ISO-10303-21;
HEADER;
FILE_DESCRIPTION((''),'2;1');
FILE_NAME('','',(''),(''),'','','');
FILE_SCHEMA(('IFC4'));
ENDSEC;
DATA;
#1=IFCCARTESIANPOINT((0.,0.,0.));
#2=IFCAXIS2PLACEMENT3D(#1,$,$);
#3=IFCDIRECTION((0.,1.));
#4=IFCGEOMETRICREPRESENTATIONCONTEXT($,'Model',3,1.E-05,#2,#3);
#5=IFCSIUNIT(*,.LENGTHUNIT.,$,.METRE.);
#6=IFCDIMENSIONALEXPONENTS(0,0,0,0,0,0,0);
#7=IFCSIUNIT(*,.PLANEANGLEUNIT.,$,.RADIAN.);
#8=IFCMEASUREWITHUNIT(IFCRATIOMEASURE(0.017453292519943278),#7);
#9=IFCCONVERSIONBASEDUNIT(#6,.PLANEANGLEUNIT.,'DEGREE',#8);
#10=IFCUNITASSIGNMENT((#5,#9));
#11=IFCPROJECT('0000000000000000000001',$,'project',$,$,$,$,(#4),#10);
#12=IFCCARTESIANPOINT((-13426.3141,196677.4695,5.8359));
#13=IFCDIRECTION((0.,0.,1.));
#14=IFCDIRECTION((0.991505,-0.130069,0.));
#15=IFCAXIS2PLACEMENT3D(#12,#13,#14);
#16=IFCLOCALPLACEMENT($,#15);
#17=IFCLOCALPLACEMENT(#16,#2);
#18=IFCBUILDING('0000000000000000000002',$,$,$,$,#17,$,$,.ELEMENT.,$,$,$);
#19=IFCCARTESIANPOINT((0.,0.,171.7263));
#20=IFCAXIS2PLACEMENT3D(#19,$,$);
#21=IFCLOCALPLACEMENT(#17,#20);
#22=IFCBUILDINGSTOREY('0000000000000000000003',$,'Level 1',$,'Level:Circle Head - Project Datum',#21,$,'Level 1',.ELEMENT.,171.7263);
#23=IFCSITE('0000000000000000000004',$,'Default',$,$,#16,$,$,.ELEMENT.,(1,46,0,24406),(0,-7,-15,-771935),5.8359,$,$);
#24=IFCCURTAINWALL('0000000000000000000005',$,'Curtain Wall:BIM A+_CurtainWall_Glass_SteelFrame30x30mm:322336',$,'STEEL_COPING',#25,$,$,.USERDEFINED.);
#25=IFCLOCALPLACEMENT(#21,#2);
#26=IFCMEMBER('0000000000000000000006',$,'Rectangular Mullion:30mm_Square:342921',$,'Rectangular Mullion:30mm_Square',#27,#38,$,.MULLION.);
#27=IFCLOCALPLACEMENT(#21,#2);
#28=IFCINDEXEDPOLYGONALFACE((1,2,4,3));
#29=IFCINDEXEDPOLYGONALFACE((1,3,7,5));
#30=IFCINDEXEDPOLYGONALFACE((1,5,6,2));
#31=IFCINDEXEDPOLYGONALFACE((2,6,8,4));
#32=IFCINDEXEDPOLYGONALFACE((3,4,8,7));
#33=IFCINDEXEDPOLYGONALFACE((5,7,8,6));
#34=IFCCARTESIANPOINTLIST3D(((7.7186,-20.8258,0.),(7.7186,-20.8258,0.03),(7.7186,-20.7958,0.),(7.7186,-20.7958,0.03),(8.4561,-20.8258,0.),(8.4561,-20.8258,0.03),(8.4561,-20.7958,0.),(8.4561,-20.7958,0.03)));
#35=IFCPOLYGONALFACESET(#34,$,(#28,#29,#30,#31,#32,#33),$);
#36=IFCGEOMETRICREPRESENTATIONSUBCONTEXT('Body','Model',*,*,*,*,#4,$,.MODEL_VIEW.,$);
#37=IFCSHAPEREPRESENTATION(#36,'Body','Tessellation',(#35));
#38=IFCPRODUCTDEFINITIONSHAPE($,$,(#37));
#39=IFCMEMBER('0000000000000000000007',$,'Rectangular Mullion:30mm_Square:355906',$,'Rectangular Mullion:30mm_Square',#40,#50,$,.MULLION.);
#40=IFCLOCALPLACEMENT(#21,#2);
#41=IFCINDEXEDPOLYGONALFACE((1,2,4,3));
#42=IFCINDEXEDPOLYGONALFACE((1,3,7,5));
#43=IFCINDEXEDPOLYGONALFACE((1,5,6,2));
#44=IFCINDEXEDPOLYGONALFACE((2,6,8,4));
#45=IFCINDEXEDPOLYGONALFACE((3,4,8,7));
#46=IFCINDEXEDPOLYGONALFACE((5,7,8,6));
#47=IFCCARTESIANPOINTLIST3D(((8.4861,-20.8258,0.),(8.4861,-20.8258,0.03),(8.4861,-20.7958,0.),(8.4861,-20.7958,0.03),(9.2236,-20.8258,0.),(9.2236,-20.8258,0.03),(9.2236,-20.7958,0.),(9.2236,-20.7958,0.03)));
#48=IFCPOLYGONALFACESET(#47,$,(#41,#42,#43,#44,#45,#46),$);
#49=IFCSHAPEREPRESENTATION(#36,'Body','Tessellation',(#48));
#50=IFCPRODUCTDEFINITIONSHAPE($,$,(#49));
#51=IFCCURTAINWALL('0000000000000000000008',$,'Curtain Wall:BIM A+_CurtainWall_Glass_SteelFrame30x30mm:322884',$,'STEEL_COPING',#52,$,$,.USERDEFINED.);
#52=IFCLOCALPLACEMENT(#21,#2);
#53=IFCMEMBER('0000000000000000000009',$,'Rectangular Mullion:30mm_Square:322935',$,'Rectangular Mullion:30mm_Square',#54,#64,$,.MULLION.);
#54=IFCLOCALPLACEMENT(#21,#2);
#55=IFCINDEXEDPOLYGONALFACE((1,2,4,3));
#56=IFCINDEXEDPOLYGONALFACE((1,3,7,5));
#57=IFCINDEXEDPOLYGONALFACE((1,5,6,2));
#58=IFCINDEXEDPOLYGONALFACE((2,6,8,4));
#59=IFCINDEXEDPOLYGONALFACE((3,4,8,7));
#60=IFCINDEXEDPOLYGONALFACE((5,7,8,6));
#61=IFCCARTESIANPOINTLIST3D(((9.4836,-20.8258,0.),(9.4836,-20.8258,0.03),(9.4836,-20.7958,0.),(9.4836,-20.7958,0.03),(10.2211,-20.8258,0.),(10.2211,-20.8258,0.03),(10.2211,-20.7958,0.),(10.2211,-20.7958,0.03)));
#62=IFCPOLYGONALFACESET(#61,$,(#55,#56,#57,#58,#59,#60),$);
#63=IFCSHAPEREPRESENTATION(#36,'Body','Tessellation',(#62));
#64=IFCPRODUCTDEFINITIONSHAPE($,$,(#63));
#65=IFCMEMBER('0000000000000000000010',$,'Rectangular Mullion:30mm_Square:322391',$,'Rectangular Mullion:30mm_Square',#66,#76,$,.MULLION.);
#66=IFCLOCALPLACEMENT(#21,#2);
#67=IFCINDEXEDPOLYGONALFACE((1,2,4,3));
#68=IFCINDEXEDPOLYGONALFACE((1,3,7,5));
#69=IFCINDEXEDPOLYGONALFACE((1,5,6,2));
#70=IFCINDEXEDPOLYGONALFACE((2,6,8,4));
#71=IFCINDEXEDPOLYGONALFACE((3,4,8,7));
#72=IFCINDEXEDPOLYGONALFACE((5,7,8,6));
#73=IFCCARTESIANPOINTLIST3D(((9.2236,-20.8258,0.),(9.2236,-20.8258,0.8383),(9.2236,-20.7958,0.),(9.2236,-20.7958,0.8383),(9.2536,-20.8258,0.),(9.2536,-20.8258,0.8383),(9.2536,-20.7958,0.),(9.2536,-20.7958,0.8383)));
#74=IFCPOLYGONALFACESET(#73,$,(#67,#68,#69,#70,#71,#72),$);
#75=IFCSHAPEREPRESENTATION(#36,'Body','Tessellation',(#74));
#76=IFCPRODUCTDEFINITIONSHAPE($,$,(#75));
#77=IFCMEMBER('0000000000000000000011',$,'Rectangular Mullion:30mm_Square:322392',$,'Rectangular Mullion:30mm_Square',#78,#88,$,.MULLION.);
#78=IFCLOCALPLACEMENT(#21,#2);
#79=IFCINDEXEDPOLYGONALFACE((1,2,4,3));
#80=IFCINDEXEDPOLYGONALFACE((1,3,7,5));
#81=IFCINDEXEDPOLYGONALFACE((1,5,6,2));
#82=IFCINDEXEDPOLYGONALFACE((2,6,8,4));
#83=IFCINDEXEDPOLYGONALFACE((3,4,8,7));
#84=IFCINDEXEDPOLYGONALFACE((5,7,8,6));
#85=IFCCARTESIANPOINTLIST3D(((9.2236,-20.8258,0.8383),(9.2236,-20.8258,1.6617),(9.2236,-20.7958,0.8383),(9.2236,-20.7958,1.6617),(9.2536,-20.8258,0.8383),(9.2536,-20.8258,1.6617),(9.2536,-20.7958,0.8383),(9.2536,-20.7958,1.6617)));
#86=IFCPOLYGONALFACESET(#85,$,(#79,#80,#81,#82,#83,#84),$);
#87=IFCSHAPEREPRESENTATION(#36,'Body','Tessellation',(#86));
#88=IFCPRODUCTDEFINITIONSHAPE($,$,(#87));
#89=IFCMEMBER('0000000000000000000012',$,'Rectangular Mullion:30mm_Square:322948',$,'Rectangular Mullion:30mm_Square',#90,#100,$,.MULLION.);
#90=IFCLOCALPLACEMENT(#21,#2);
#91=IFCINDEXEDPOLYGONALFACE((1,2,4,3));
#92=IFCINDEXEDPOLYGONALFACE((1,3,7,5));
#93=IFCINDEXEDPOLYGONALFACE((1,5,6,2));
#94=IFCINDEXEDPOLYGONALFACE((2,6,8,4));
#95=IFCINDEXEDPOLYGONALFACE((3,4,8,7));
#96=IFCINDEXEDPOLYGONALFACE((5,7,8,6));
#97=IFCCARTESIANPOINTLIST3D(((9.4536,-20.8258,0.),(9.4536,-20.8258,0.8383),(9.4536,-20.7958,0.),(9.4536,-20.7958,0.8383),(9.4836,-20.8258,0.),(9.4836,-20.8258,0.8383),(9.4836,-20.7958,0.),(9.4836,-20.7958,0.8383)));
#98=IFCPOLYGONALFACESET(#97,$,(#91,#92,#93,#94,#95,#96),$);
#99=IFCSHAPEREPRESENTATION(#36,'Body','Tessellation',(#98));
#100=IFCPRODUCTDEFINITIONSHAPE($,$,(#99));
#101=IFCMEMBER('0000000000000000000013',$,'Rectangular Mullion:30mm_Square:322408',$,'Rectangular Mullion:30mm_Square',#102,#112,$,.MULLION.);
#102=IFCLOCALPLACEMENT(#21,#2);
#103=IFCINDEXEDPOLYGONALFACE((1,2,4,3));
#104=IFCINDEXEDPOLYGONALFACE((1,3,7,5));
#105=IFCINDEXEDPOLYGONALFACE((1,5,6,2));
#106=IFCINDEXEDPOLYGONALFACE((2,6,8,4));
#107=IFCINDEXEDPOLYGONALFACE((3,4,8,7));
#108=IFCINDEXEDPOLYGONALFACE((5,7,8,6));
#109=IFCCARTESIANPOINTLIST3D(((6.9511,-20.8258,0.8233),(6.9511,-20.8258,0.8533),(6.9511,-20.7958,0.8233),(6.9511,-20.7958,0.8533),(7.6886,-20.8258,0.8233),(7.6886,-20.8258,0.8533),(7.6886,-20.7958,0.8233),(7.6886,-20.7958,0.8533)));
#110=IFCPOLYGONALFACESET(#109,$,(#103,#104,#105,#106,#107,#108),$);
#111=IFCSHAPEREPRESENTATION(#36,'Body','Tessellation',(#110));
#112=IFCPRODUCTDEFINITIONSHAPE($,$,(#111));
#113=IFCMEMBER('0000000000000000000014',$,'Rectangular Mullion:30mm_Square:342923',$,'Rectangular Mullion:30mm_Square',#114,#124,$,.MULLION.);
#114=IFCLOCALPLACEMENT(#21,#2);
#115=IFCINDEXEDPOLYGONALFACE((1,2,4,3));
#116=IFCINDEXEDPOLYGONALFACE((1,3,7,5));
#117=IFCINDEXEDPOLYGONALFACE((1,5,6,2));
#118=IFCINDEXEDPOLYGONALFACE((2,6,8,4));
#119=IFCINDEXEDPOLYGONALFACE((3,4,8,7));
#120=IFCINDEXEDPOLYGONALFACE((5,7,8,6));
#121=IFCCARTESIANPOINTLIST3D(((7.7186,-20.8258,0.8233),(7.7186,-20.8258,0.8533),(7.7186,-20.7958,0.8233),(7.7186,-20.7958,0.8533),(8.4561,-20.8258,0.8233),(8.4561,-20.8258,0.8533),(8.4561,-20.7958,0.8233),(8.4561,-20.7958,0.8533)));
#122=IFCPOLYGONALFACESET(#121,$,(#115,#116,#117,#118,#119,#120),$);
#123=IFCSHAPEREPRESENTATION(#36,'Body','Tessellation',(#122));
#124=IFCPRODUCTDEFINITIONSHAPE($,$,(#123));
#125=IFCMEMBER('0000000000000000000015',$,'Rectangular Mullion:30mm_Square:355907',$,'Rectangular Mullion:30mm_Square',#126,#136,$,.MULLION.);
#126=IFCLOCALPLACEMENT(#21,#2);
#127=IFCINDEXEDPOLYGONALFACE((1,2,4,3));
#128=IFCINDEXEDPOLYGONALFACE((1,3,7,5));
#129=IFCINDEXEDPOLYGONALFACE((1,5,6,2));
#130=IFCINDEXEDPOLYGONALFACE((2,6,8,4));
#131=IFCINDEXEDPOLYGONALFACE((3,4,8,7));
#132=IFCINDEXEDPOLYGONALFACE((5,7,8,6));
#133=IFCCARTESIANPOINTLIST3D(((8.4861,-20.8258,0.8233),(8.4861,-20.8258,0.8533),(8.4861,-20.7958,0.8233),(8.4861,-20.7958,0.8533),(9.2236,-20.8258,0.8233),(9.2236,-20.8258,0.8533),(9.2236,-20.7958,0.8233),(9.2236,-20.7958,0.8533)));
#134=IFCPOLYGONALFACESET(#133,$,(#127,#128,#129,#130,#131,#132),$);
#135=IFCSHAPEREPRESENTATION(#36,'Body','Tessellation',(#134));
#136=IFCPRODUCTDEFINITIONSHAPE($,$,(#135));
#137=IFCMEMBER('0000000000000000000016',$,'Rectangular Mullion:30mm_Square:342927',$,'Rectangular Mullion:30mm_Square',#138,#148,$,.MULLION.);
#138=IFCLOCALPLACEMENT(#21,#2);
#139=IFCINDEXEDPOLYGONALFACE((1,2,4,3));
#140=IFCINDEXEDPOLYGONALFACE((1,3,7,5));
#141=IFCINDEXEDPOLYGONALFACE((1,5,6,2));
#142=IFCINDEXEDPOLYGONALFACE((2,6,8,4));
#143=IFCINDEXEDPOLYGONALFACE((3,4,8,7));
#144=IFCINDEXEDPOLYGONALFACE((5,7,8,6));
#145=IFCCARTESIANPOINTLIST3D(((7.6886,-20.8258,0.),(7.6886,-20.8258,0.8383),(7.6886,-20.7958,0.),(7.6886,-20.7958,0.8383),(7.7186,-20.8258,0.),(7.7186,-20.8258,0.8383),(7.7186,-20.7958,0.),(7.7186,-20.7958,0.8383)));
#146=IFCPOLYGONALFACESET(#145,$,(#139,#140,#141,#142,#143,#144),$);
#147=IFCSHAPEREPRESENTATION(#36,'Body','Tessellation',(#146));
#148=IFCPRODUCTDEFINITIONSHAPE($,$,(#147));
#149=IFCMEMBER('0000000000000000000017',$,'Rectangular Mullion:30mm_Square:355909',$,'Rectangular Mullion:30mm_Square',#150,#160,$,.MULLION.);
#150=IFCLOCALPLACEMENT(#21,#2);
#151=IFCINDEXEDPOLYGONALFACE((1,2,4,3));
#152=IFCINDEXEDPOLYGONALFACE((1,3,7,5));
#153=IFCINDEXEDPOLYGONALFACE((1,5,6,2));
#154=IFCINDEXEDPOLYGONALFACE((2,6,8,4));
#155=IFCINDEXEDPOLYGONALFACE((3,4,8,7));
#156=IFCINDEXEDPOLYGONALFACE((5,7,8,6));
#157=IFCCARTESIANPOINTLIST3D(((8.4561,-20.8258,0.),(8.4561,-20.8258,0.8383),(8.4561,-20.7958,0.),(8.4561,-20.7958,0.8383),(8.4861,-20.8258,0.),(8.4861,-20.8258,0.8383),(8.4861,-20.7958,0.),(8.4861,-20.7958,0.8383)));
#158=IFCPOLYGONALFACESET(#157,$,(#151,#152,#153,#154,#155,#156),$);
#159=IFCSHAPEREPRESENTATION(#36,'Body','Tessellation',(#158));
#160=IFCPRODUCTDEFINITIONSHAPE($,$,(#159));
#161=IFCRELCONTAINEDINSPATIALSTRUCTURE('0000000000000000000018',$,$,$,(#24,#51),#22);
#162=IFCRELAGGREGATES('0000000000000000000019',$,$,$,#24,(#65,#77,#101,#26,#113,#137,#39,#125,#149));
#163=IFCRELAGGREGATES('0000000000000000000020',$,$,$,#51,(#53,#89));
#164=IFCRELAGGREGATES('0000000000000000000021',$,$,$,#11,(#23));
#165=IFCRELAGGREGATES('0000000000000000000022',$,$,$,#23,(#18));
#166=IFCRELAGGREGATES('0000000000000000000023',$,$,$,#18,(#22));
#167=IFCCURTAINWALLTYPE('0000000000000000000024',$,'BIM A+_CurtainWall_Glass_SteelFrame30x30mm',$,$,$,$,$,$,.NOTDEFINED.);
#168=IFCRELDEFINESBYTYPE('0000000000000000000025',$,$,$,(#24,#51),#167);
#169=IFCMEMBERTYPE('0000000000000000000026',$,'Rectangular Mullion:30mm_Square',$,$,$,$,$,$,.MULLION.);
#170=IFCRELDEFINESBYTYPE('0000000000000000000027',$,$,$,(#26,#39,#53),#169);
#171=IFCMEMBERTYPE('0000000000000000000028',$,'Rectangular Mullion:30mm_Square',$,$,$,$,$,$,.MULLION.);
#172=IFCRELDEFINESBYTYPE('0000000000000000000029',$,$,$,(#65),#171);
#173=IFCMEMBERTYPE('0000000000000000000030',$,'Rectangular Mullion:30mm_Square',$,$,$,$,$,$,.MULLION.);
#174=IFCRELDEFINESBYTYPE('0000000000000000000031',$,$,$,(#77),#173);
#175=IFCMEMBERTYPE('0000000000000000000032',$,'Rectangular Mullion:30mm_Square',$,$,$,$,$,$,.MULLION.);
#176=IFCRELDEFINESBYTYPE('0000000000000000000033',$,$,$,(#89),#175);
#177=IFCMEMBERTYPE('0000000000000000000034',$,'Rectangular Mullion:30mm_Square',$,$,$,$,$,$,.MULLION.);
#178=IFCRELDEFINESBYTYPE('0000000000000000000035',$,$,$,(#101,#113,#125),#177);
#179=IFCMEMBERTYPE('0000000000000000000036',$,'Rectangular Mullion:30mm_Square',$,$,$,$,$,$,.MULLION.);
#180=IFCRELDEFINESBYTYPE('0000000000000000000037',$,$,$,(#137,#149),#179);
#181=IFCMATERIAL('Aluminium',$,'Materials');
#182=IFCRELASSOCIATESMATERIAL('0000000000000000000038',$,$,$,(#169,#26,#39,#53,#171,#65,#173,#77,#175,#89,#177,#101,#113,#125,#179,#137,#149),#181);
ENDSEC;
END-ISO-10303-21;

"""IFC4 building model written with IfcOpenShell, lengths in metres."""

from ifc_helpers import new_model, entity, si_unit, converted_unit, direction, frame, origin, place, context, subcontext, project, spatial, indexed_curve, outline, extrude, source, transform, mapped, material, type_object, type_shapes, element, aggregate, save


model = new_model("IFC4")

# Units and contexts
model_context = context("Model", 3, precision=1e-05, world=origin(), true_north=direction((0.0, 1.0)))
body_context = subcontext(model_context, "Body", "Model", "MODEL_VIEW")
ifc_project = project(units=[si_unit("LENGTHUNIT", "METRE"), converted_unit("PLANEANGLEUNIT", "DEGREE", entity("IfcRatioMeasure", 0.017453292519943278), si_unit("PLANEANGLEUNIT", "RADIAN"), dimensions=[0, 0, 0, 0, 0, 0, 0])], contexts=[model_context])

# Site, building, storey
site_placement = place(None, frame((-13426.3141, 196677.4695, 5.8359), z_axis=(0.0, 0.0, 1.0), x_axis=(0.991505, -0.130069, 0.0)))
site = spatial("IfcSite", under=ifc_project, at=site_placement, Name="Default", CompositionType="ELEMENT", RefLatitude=(1, 46, 0, 24406), RefLongitude=(0, -7, -15, -771935), RefElevation=5.8359)
building_placement = place(site_placement, origin())
building = spatial("IfcBuilding", under=site, at=building_placement, CompositionType="ELEMENT")
storey_placement = place(building_placement, frame((0.0, 0.0, 171.7263)))
storey = spatial("IfcBuildingStorey", under=building, at=storey_placement, Name="Level 1", ObjectType="Level:Circle Head - Project Datum", LongName="Level 1", CompositionType="ELEMENT", Elevation=171.7263)

# Curtain wall, members
curtain_wall_type_1 = type_object("IfcCurtainWallType", Name="BIM A+_CurtainWall_Glass_SteelFrame30x30mm", PredefinedType="NOTDEFINED")
curtain_wall_1_placement = place(storey_placement, frame((0.0, 0.0, -171.7263)))
curtain_wall_1 = element("IfcCurtainWall", 1, at=curtain_wall_1_placement, inside=storey, type_object=curtain_wall_type_1, Name="Curtain Wall:BIM A+_CurtainWall_Glass_SteelFrame30x30mm:322336", ObjectType="STEEL_COPING", PredefinedType="USERDEFINED")
ifc_material_1 = material(Name="Aluminium", Category="Materials")
member_type_1 = type_object("IfcMemberType", Name="Rectangular Mullion:30mm_Square", PredefinedType="MULLION", material=ifc_material_1)
shared_shape_1 = source(origin(), body_context, "Body", "SweptSolid", [
    extrude(outline(indexed_curve([(-0.015, -0.015), (0.015, -0.015), (0.015, 0.015), (-0.015, 0.015), (-0.015, -0.015)], self_intersect=False)), frame((-0.015, 0.0, -0.7375), z_axis=(0.0, 0.0, 1.0), x_axis=(0.0, -1.0, 0.0)), (0.0, 0.0, 1.0), 0.7375),
])
type_shapes(member_type_1, [shared_shape_1])
member_1_placement = place(curtain_wall_1_placement, frame((7.7186, -20.8108, 171.7263), z_axis=(-1.0, 0.0, 0.0), x_axis=(0.0, 0.0, -1.0)))
member_1 = element("IfcMember", 2, at=member_1_placement, type_object=member_type_1, material=ifc_material_1, Name="Rectangular Mullion:30mm_Square:342921", ObjectType="Rectangular Mullion:30mm_Square", PredefinedType="MULLION", context=body_context, shape_type="MappedRepresentation", body=[
    mapped(shared_shape_1, transform((0.0, 0.0, 0.0), scale=1.0)),
])
member_2_placement = place(curtain_wall_1_placement, frame((8.4861, -20.8108, 171.7263), z_axis=(-1.0, 0.0, 0.0), x_axis=(0.0, 0.0, -1.0)))
member_2 = element("IfcMember", 3, at=member_2_placement, type_object=member_type_1, material=ifc_material_1, Name="Rectangular Mullion:30mm_Square:355906", ObjectType="Rectangular Mullion:30mm_Square", PredefinedType="MULLION", context=body_context, shape_type="MappedRepresentation", body=[
    mapped(shared_shape_1, transform((0.0, 0.0, 0.0), scale=1.0)),
])

# Curtain wall, member
curtain_wall_2_placement = place(storey_placement, frame((0.0, 0.0, -171.7263)))
curtain_wall_2 = element("IfcCurtainWall", 4, at=curtain_wall_2_placement, inside=storey, type_object=curtain_wall_type_1, Name="Curtain Wall:BIM A+_CurtainWall_Glass_SteelFrame30x30mm:322884", ObjectType="STEEL_COPING", PredefinedType="USERDEFINED")
member_3_placement = place(curtain_wall_2_placement, frame((9.4836, -20.8108, 171.7263), z_axis=(-1.0, 0.0, 0.0), x_axis=(0.0, 0.0, -1.0)))
member_3 = element("IfcMember", 5, at=member_3_placement, type_object=member_type_1, material=ifc_material_1, Name="Rectangular Mullion:30mm_Square:322935", ObjectType="Rectangular Mullion:30mm_Square", PredefinedType="MULLION", context=body_context, shape_type="MappedRepresentation", body=[
    mapped(shared_shape_1, transform((0.0, 0.0, 0.0), scale=1.0)),
])

# Members
member_type_2 = type_object("IfcMemberType", Name="Rectangular Mullion:30mm_Square", PredefinedType="MULLION", material=ifc_material_1)
shared_shape_2 = source(origin(), body_context, "Body", "SweptSolid", [
    extrude(outline(indexed_curve([(-0.015, -0.015), (0.015, -0.015), (0.015, 0.015), (-0.015, 0.015), (-0.015, -0.015)], self_intersect=False)), frame((-0.015, 0.0, -0.8383), z_axis=(0.0, 0.0, 1.0), x_axis=(0.0, -1.0, 0.0)), (0.0, 0.0, 1.0), 0.8383),
])
type_shapes(member_type_2, [shared_shape_2])
member_4_placement = place(curtain_wall_1_placement, frame((9.2536, -20.8108, 171.7263), z_axis=(0.0, 0.0, -1.0), x_axis=(1.0, 0.0, 0.0)))
member_4 = element("IfcMember", 6, at=member_4_placement, type_object=member_type_2, material=ifc_material_1, Name="Rectangular Mullion:30mm_Square:322391", ObjectType="Rectangular Mullion:30mm_Square", PredefinedType="MULLION", context=body_context, shape_type="MappedRepresentation", body=[
    mapped(shared_shape_2, transform((0.0, 0.0, 0.0), scale=1.0)),
])
member_type_3 = type_object("IfcMemberType", Name="Rectangular Mullion:30mm_Square", PredefinedType="MULLION", material=ifc_material_1)
shared_shape_3 = source(origin(), body_context, "Body", "SweptSolid", [
    extrude(outline(indexed_curve([(-0.015, -0.015), (0.015, -0.015), (0.015, 0.015), (-0.015, 0.015), (-0.015, -0.015)], self_intersect=False)), frame((-0.015, 0.0, -0.8233), z_axis=(0.0, 0.0, 1.0), x_axis=(0.0, -1.0, 0.0)), (0.0, 0.0, 1.0), 0.8233),
])
type_shapes(member_type_3, [shared_shape_3])
member_5_placement = place(curtain_wall_1_placement, frame((9.2536, -20.8108, 172.5646), z_axis=(0.0, 0.0, -1.0), x_axis=(1.0, 0.0, 0.0)))
member_5 = element("IfcMember", 7, at=member_5_placement, type_object=member_type_3, material=ifc_material_1, Name="Rectangular Mullion:30mm_Square:322392", ObjectType="Rectangular Mullion:30mm_Square", PredefinedType="MULLION", context=body_context, shape_type="MappedRepresentation", body=[
    mapped(shared_shape_3, transform((0.0, 0.0, 0.0), scale=1.0)),
])
member_type_4 = type_object("IfcMemberType", Name="Rectangular Mullion:30mm_Square", PredefinedType="MULLION", material=ifc_material_1)
shared_shape_4 = source(origin(), body_context, "Body", "SweptSolid", [
    extrude(outline(indexed_curve([(-0.015, -0.015), (0.015, -0.015), (0.015, 0.015), (-0.015, 0.015), (-0.015, -0.015)], self_intersect=False)), frame((-0.015, 0.0, -0.8383), z_axis=(0.0, 0.0, 1.0), x_axis=(0.0, -1.0, 0.0)), (0.0, 0.0, 1.0), 0.8383),
])
type_shapes(member_type_4, [shared_shape_4])
member_6_placement = place(curtain_wall_2_placement, frame((9.4536, -20.8108, 172.5646), z_axis=(0.0, 0.0, 1.0), x_axis=(-1.0, 0.0, 0.0)))
member_6 = element("IfcMember", 8, at=member_6_placement, type_object=member_type_4, material=ifc_material_1, Name="Rectangular Mullion:30mm_Square:322948", ObjectType="Rectangular Mullion:30mm_Square", PredefinedType="MULLION", context=body_context, shape_type="MappedRepresentation", body=[
    mapped(shared_shape_4, transform((0.0, 0.0, 0.0), scale=1.0)),
])
member_type_5 = type_object("IfcMemberType", Name="Rectangular Mullion:30mm_Square", PredefinedType="MULLION", material=ifc_material_1)
shared_shape_5 = source(origin(), body_context, "Body", "SweptSolid", [
    extrude(outline(indexed_curve([(-0.015, -0.015), (0.015, -0.015), (0.015, 0.015), (-0.015, 0.015), (-0.015, -0.015)], self_intersect=False)), frame((0.0, 0.0, -0.7375), z_axis=(0.0, 0.0, 1.0), x_axis=(0.0, -1.0, 0.0)), (0.0, 0.0, 1.0), 0.7375),
])
type_shapes(member_type_5, [shared_shape_5])
member_7_placement = place(curtain_wall_1_placement, frame((7.6886, -20.8108, 172.5646), z_axis=(1.0, 0.0, 0.0), x_axis=(0.0, 0.0, 1.0)))
member_7 = element("IfcMember", 9, at=member_7_placement, type_object=member_type_5, material=ifc_material_1, Name="Rectangular Mullion:30mm_Square:322408", ObjectType="Rectangular Mullion:30mm_Square", PredefinedType="MULLION", context=body_context, shape_type="MappedRepresentation", body=[
    mapped(shared_shape_5, transform((0.0, 0.0, 0.0), scale=1.0)),
])
member_8_placement = place(curtain_wall_1_placement, frame((8.4561, -20.8108, 172.5646), z_axis=(1.0, 0.0, 0.0), x_axis=(0.0, 0.0, 1.0)))
member_8 = element("IfcMember", 10, at=member_8_placement, type_object=member_type_5, material=ifc_material_1, Name="Rectangular Mullion:30mm_Square:342923", ObjectType="Rectangular Mullion:30mm_Square", PredefinedType="MULLION", context=body_context, shape_type="MappedRepresentation", body=[
    mapped(shared_shape_5, transform((0.0, 0.0, 0.0), scale=1.0)),
])
member_9_placement = place(curtain_wall_1_placement, frame((9.2236, -20.8108, 172.5646), z_axis=(1.0, 0.0, 0.0), x_axis=(0.0, 0.0, 1.0)))
member_9 = element("IfcMember", 11, at=member_9_placement, type_object=member_type_5, material=ifc_material_1, Name="Rectangular Mullion:30mm_Square:355907", ObjectType="Rectangular Mullion:30mm_Square", PredefinedType="MULLION", context=body_context, shape_type="MappedRepresentation", body=[
    mapped(shared_shape_5, transform((0.0, 0.0, 0.0), scale=1.0)),
])
member_type_6 = type_object("IfcMemberType", Name="Rectangular Mullion:30mm_Square", PredefinedType="MULLION", material=ifc_material_1)
shared_shape_6 = source(origin(), body_context, "Body", "SweptSolid", [
    extrude(outline(indexed_curve([(-0.015, -0.015), (0.015, -0.015), (0.015, 0.015), (-0.015, 0.015), (-0.015, -0.015)], self_intersect=False)), frame((0.0, 0.0, -0.8383), z_axis=(0.0, 0.0, 1.0), x_axis=(0.0, -1.0, 0.0)), (0.0, 0.0, 1.0), 0.8383),
])
type_shapes(member_type_6, [shared_shape_6])
member_10_placement = place(curtain_wall_1_placement, frame((7.7036, -20.8108, 171.7263), z_axis=(0.0, 0.0, -1.0), x_axis=(1.0, 0.0, 0.0)))
member_10 = element("IfcMember", 12, at=member_10_placement, type_object=member_type_6, material=ifc_material_1, Name="Rectangular Mullion:30mm_Square:342927", ObjectType="Rectangular Mullion:30mm_Square", PredefinedType="MULLION", context=body_context, shape_type="MappedRepresentation", body=[
    mapped(shared_shape_6, transform((0.0, 0.0, 0.0), scale=1.0)),
])
member_11_placement = place(curtain_wall_1_placement, frame((8.4711, -20.8108, 171.7263), z_axis=(0.0, 0.0, -1.0), x_axis=(1.0, 0.0, 0.0)))
member_11 = element("IfcMember", 13, at=member_11_placement, type_object=member_type_6, material=ifc_material_1, Name="Rectangular Mullion:30mm_Square:355909", ObjectType="Rectangular Mullion:30mm_Square", PredefinedType="MULLION", context=body_context, shape_type="MappedRepresentation", body=[
    mapped(shared_shape_6, transform((0.0, 0.0, 0.0), scale=1.0)),
])

aggregate(curtain_wall_1, [member_4, member_5, member_7, member_1, member_8, member_10, member_2, member_9, member_11])
aggregate(curtain_wall_2, [member_3, member_6])

save(model, "model.ifc")
